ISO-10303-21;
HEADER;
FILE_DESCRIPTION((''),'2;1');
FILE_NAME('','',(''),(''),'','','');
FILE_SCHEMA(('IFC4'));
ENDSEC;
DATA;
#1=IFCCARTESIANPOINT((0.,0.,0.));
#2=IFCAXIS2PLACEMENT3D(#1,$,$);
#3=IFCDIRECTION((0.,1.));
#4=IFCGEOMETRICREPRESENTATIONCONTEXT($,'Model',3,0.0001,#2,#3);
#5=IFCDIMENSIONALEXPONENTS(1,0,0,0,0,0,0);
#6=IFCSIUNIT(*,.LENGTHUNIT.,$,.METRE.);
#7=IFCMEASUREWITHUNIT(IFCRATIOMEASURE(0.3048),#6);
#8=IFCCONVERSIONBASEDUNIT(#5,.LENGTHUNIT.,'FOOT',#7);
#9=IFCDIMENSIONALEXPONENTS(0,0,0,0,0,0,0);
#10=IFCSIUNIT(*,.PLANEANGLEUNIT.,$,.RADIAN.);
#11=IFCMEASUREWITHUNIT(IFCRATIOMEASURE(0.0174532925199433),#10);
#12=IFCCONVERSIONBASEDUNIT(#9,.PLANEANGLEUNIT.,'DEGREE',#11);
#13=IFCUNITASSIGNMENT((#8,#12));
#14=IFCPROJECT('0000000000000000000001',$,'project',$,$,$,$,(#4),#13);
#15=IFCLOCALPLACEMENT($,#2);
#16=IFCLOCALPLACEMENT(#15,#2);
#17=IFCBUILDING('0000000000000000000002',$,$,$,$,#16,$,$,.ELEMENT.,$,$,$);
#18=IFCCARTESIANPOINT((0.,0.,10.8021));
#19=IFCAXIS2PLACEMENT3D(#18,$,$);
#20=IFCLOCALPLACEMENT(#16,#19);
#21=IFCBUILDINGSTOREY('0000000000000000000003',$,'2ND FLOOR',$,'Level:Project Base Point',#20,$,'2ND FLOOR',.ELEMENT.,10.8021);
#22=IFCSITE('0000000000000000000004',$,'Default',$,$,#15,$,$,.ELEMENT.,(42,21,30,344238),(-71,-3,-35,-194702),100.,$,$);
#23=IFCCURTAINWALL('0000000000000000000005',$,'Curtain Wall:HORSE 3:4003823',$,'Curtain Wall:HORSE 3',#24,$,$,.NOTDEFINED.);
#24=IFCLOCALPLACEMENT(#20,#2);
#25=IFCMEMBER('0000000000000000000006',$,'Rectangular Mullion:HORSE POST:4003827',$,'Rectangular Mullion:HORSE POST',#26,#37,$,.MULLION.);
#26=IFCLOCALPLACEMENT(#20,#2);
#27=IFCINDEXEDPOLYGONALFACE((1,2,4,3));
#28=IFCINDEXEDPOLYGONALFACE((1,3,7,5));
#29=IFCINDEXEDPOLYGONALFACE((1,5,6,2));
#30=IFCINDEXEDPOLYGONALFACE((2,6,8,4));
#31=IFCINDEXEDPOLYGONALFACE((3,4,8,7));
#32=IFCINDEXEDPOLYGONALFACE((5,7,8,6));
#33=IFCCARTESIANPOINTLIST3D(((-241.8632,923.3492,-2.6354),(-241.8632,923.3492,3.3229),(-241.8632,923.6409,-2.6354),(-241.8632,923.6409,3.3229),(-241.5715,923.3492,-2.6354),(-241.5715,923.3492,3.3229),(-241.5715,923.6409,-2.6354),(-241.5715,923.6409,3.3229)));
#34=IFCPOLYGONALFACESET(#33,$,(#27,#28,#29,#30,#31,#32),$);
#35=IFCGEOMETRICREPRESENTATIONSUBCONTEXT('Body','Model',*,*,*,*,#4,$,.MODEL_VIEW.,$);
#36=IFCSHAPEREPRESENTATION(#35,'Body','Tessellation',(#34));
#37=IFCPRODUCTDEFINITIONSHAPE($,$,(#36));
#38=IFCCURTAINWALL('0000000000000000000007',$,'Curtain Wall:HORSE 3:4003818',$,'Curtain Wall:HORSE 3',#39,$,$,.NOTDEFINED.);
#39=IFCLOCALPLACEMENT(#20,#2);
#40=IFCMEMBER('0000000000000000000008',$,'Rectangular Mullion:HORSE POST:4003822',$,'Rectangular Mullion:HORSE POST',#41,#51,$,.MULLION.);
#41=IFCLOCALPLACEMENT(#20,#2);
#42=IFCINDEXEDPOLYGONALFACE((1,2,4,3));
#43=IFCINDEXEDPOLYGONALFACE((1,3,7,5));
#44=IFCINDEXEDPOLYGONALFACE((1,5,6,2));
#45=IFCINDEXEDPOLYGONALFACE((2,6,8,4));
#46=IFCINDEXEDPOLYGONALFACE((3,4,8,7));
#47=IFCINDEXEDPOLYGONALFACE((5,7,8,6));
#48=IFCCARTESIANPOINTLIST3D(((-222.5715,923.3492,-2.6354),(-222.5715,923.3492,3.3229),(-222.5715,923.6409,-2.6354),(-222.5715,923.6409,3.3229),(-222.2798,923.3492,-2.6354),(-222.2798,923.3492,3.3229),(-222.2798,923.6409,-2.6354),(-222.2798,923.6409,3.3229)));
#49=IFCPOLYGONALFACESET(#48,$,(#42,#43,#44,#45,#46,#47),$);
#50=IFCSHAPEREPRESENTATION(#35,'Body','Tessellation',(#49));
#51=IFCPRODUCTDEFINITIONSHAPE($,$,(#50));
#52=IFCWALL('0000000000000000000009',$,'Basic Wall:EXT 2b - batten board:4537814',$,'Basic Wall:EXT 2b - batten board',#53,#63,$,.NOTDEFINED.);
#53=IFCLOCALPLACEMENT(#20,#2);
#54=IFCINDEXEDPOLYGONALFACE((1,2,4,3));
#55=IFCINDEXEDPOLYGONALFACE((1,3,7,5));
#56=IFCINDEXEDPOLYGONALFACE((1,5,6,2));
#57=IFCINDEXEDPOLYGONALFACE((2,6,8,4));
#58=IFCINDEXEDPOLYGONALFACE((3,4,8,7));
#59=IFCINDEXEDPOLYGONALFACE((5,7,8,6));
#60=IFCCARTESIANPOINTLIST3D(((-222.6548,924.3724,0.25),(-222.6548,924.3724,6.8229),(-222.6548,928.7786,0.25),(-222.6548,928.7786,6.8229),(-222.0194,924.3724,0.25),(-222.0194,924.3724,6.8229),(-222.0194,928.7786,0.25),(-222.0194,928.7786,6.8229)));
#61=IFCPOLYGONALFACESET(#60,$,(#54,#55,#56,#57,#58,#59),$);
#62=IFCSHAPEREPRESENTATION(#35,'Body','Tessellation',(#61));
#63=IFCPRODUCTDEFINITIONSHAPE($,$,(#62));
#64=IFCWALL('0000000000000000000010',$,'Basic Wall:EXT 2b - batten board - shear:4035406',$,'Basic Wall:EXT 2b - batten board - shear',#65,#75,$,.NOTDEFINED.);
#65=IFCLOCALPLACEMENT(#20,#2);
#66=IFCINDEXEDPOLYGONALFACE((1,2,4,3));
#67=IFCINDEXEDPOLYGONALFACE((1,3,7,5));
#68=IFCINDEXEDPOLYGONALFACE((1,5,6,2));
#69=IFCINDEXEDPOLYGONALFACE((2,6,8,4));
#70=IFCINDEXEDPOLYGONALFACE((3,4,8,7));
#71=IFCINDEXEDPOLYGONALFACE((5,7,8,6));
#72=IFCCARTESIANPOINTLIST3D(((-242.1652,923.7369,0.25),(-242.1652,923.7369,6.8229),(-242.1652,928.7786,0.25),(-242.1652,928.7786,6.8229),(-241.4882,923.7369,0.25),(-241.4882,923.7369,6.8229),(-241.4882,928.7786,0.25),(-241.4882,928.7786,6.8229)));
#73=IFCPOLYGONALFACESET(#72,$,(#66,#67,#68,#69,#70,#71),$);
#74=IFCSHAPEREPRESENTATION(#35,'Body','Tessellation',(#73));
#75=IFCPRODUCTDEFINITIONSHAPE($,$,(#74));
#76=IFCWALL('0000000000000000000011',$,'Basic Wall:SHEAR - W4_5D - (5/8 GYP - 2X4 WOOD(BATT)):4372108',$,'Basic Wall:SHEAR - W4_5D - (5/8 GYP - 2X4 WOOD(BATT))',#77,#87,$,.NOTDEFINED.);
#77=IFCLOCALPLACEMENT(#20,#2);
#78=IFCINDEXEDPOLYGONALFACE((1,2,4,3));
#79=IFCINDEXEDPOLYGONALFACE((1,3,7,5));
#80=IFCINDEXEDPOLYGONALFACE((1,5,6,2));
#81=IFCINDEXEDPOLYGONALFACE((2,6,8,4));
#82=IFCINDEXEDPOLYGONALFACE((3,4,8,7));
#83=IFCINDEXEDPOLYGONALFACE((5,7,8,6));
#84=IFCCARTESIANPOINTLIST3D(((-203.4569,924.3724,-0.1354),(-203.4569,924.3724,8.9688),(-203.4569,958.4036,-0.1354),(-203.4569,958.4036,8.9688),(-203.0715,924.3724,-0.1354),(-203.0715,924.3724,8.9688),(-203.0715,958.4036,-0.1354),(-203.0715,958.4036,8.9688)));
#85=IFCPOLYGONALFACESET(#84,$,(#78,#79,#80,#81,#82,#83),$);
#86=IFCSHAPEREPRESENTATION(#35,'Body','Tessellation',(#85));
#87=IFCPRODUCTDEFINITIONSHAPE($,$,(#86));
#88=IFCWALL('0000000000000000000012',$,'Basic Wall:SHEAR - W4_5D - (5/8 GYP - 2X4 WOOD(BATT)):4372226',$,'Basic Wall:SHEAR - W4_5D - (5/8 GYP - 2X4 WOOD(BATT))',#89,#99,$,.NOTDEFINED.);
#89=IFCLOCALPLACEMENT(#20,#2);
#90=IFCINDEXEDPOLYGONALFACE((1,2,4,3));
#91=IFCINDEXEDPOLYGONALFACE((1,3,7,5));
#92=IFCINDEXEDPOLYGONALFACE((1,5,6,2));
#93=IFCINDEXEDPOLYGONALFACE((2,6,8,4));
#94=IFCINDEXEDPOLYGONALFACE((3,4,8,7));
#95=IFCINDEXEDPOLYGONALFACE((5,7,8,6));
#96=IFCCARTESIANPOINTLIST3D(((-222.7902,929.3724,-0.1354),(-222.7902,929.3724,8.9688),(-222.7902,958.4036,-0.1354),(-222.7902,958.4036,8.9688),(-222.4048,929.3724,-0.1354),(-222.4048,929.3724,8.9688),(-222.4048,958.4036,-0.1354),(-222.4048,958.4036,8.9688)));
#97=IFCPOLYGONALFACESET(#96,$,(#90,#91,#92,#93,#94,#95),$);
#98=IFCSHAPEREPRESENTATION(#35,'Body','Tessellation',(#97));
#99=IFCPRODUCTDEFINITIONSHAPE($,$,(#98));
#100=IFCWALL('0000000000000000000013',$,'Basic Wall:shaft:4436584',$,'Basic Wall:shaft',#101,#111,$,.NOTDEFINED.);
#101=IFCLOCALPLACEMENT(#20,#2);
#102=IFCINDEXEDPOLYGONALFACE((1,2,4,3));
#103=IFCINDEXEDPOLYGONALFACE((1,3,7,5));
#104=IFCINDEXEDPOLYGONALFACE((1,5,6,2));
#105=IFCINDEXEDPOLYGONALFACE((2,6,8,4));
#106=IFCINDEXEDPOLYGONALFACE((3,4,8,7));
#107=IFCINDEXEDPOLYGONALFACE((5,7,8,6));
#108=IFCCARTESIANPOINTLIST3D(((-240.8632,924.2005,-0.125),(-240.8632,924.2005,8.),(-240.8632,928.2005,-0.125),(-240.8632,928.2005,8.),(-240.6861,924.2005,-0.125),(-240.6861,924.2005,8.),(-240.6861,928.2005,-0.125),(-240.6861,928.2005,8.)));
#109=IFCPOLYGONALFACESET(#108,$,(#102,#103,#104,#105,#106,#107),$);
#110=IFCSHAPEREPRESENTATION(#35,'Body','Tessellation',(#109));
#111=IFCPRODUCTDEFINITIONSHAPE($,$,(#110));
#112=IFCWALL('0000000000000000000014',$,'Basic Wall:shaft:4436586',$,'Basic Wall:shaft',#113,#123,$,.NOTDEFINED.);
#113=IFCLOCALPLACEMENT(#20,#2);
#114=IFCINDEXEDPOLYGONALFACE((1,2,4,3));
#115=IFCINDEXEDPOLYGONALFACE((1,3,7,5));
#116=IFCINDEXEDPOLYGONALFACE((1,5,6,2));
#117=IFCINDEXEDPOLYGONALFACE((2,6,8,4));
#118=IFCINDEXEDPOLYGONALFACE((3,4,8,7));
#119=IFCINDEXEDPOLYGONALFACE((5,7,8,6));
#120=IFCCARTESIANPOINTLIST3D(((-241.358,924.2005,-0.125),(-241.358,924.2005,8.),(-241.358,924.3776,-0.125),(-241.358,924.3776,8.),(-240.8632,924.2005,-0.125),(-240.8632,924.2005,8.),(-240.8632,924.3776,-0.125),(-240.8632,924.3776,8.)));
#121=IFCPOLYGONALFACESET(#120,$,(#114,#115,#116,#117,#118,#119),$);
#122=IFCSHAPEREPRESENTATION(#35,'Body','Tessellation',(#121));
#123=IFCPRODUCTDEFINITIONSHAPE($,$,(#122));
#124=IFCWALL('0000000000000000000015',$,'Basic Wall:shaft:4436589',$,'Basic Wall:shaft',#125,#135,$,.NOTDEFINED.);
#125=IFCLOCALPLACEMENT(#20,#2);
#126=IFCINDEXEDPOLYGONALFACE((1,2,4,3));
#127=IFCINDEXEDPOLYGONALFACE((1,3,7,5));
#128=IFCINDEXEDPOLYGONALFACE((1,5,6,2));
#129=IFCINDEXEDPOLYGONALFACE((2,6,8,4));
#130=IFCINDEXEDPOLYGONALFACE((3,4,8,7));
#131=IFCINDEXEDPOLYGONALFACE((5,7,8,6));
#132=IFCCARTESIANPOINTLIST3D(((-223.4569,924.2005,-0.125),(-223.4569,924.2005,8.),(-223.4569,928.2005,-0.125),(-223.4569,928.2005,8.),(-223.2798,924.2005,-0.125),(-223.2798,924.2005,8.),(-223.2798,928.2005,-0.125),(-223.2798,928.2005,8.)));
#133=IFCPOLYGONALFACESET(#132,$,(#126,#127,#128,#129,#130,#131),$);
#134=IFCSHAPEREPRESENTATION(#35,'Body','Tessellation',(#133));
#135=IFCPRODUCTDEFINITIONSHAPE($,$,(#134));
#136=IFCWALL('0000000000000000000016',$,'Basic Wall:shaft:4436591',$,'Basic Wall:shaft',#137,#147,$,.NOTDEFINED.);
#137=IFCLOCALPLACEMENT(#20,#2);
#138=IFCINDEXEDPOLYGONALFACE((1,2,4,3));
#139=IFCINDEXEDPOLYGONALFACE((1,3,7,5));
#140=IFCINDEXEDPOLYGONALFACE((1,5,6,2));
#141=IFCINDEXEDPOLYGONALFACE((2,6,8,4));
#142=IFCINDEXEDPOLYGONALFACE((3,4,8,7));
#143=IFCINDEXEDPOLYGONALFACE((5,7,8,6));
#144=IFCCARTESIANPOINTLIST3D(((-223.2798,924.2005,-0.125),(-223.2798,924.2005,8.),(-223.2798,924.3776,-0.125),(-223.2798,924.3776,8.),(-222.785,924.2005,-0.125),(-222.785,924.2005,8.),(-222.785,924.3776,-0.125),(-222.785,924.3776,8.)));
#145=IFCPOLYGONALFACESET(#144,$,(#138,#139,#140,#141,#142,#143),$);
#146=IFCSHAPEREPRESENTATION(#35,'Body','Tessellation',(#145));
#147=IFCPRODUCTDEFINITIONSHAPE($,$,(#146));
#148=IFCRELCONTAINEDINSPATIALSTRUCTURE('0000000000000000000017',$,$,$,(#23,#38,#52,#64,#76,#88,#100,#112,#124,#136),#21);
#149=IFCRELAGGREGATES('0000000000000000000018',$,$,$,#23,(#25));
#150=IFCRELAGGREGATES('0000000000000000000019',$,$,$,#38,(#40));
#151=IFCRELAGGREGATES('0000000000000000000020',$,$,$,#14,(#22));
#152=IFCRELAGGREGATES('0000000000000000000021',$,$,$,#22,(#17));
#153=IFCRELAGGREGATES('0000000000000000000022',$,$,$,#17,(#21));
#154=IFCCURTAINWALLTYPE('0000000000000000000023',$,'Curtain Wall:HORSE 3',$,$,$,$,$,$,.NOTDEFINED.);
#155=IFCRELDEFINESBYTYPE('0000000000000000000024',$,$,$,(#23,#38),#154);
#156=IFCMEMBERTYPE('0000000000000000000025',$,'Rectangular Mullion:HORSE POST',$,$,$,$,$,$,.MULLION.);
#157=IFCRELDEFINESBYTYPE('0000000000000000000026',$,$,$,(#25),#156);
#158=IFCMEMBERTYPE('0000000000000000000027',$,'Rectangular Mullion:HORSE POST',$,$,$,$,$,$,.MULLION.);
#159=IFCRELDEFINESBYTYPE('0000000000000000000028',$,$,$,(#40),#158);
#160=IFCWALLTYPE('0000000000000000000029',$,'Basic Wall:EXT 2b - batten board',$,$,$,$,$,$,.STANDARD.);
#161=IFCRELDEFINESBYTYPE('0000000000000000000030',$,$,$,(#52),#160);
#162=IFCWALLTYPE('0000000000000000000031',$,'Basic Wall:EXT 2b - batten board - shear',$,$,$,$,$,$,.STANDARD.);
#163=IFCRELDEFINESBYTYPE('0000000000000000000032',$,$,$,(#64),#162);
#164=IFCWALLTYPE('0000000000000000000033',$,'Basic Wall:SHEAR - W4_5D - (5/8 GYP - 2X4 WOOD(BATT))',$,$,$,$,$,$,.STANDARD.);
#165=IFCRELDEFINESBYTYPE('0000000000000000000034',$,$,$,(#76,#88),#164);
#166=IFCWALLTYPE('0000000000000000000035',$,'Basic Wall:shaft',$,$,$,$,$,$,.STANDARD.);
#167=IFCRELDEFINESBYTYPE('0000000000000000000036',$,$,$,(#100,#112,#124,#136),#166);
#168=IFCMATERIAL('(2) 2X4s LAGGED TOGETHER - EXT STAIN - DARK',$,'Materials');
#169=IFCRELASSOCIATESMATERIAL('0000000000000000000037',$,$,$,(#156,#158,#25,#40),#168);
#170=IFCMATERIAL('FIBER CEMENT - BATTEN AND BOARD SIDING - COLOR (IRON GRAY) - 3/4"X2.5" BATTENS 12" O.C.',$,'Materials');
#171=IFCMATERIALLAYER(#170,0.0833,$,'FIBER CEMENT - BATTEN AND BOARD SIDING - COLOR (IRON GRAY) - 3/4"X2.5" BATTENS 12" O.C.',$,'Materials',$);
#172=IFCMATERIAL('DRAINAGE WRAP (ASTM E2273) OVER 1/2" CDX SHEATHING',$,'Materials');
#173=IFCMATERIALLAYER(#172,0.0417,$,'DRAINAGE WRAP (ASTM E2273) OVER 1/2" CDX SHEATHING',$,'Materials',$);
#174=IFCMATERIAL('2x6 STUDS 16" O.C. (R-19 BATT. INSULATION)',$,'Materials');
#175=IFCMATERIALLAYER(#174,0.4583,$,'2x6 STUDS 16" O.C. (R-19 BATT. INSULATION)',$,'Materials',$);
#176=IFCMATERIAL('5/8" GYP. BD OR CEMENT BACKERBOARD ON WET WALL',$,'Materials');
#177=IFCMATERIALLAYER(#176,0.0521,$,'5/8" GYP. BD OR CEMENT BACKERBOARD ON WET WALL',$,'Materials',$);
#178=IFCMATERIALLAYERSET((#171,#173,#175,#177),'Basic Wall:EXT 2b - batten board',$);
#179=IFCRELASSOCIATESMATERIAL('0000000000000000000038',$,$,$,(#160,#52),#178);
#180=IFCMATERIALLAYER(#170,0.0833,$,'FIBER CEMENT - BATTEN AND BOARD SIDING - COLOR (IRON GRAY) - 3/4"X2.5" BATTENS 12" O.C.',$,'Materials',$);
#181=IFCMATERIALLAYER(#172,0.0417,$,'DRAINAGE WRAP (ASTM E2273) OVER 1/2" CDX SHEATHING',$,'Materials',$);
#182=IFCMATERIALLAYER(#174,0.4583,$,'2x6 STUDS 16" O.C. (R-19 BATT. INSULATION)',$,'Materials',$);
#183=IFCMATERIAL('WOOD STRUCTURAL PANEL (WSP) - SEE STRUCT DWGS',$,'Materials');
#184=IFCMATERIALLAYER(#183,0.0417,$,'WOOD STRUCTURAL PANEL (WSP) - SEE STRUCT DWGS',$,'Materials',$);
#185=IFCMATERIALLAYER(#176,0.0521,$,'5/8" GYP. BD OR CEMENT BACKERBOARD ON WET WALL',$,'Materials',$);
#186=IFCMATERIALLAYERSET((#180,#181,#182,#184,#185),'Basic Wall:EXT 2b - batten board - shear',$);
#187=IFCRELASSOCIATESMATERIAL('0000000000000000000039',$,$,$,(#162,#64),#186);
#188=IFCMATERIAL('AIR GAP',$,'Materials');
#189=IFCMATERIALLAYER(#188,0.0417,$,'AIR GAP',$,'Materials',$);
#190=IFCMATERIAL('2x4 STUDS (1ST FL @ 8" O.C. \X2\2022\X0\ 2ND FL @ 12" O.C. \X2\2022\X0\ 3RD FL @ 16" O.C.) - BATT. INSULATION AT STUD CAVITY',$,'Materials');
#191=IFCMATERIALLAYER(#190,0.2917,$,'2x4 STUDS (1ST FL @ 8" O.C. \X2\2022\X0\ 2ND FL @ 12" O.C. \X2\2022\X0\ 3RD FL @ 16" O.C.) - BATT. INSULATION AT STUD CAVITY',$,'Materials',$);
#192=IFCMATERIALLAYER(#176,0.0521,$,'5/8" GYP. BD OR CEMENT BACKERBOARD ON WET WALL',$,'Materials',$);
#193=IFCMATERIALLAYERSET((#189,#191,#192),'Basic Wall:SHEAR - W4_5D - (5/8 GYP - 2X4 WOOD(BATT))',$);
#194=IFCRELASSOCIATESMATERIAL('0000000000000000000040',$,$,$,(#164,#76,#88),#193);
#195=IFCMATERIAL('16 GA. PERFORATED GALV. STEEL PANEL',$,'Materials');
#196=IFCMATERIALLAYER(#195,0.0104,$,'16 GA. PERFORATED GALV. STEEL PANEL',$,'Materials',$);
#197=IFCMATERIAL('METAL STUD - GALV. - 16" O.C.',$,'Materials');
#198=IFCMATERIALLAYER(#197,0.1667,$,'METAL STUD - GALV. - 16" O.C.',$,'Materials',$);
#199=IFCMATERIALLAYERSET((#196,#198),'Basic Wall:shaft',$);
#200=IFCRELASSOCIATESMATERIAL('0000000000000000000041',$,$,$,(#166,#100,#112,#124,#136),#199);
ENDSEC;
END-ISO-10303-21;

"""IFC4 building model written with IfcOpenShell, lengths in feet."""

from ifc_helpers import new_model, entity, si_unit, converted_unit, direction, frame, frame_2d, origin, origin_2d_with_axis, place, context, subcontext, project, spatial, rectangle, extrude, source, transform, mapped, material, layer, layer_set, layer_usage, material_profile, profile_set, profile_usage, type_object, type_shapes, element, aggregate, save


model = new_model("IFC4")

# Units and contexts
model_context = context("Model", 3, precision=0.0001, world=origin(), true_north=direction((0.0, 1.0)))
body_context = subcontext(model_context, "Body", "Model", "MODEL_VIEW")
ifc_project = project(units=[converted_unit("LENGTHUNIT", "FOOT", entity("IfcRatioMeasure", 0.3048), si_unit("LENGTHUNIT", "METRE"), dimensions=[1, 0, 0, 0, 0, 0, 0]), converted_unit("PLANEANGLEUNIT", "DEGREE", entity("IfcRatioMeasure", 0.0174532925199433), si_unit("PLANEANGLEUNIT", "RADIAN"), dimensions=[0, 0, 0, 0, 0, 0, 0])], contexts=[model_context])

# Site, building, storey
site_placement = place(None, origin())
site = spatial("IfcSite", under=ifc_project, at=site_placement, Name="Default", CompositionType="ELEMENT", RefLatitude=(42, 21, 30, 344238), RefLongitude=(-71, -3, -35, -194702), RefElevation=100.0)
building_placement = place(site_placement, origin())
building = spatial("IfcBuilding", under=site, at=building_placement, CompositionType="ELEMENT")
storey_placement = place(building_placement, frame((0.0, 0.0, 10.8021)))
storey = spatial("IfcBuildingStorey", under=building, at=storey_placement, Name="2ND FLOOR", ObjectType="Level:Project Base Point", LongName="2ND FLOOR", CompositionType="ELEMENT", Elevation=10.8021)

# Curtain walls, members
curtain_wall_type = type_object("IfcCurtainWallType", Name="Curtain Wall:HORSE 3", PredefinedType="NOTDEFINED")
curtain_wall_1_placement = place(storey_placement, frame((0.0, 0.0, -10.8021)))
curtain_wall_1 = element("IfcCurtainWall", 1, at=curtain_wall_1_placement, inside=storey, type_object=curtain_wall_type, Name="Curtain Wall:HORSE 3:4003823", ObjectType="Curtain Wall:HORSE 3", PredefinedType="NOTDEFINED")
ifc_material_1 = material(Name="(2) 2X4s LAGGED TOGETHER - EXT STAIN - DARK", Category="Materials")
ifc_material_profile = material_profile(ifc_material_1, rectangle(XDim=0.2917, YDim=0.2917, at=frame_2d((0.0, 0.0), x_axis=(1.0, 0.0))), Name="HORSE POST")
ifc_profile_set = profile_set([ifc_material_profile], Name="HORSE POST")
ifc_profile_usage_1 = profile_usage(ifc_profile_set)
member_type_1 = type_object("IfcMemberType", Name="Rectangular Mullion:HORSE POST", PredefinedType="MULLION", material=ifc_profile_set)
shared_shape_1 = source(origin(), body_context, "Body", "SweptSolid", [
    extrude(rectangle(XDim=0.2917, YDim=0.2917, at=origin_2d_with_axis()), frame((-0.1458, 0.1458, -5.9583), z_axis=(0.0, 0.0, 1.0), x_axis=(0.0, -1.0, 0.0)), (0.0, 0.0, 1.0), 5.9583),
])
type_shapes(member_type_1, [shared_shape_1])
placement = place(building_placement, frame((0.0, 0.0, 21.4688)))
member_1_placement = place(placement, frame((-241.5715, 923.6409, -7.3438), z_axis=(0.0, 0.0, 1.0), x_axis=(0.0, 1.0, 0.0)))
member_1 = element("IfcMember", 2, at=member_1_placement, type_object=member_type_1, material=ifc_profile_usage_1, Name="Rectangular Mullion:HORSE POST:4003827", ObjectType="Rectangular Mullion:HORSE POST", PredefinedType="MULLION", context=body_context, shape_type="MappedRepresentation", body=[
    mapped(shared_shape_1, transform((0.0, 0.0, 0.0), scale=1.0)),
])
aggregate(curtain_wall_1, [member_1])
curtain_wall_2_placement = place(storey_placement, frame((0.0, 0.0, -10.8021)))
curtain_wall_2 = element("IfcCurtainWall", 3, at=curtain_wall_2_placement, inside=storey, type_object=curtain_wall_type, Name="Curtain Wall:HORSE 3:4003818", ObjectType="Curtain Wall:HORSE 3", PredefinedType="NOTDEFINED")
ifc_profile_usage_2 = profile_usage(ifc_profile_set)
member_type_2 = type_object("IfcMemberType", Name="Rectangular Mullion:HORSE POST", PredefinedType="MULLION", material=ifc_profile_set)
shared_shape_2 = source(origin(), body_context, "Body", "SweptSolid", [
    extrude(rectangle(XDim=0.2917, YDim=0.2917, at=frame_2d((0.0, 0.0), x_axis=(1.0, 0.0))), frame((-0.1458, -0.1458, -5.9583), z_axis=(0.0, 0.0, 1.0), x_axis=(0.0, -1.0, 0.0)), (0.0, 0.0, 1.0), 5.9583),
])
type_shapes(member_type_2, [shared_shape_2])
member_2_placement = place(placement, frame((-222.5715, 923.6409, -7.3437), z_axis=(0.0, 0.0, 1.0), x_axis=(0.0, 1.0, 0.0)))
member_2 = element("IfcMember", 4, at=member_2_placement, type_object=member_type_2, material=ifc_profile_usage_2, Name="Rectangular Mullion:HORSE POST:4003822", ObjectType="Rectangular Mullion:HORSE POST", PredefinedType="MULLION", context=body_context, shape_type="MappedRepresentation", body=[
    mapped(shared_shape_2, transform((0.0, 0.0, 0.0), scale=1.0)),
])
aggregate(curtain_wall_2, [member_2])

# Walls
ifc_material_2 = material(Name="FIBER CEMENT - BATTEN AND BOARD SIDING - COLOR (IRON GRAY) - 3/4\"X2.5\" BATTENS 12\" O.C.", Category="Materials")
ifc_layer_1 = layer(ifc_material_2, 0.0833, Name="FIBER CEMENT - BATTEN AND BOARD SIDING - COLOR (IRON GRAY) - 3/4\"X2.5\" BATTENS 12\" O.C.", Category="Materials")
ifc_material_3 = material(Name="DRAINAGE WRAP (ASTM E2273) OVER 1/2\" CDX SHEATHING", Category="Materials")
ifc_layer_2 = layer(ifc_material_3, 0.0417, Name="DRAINAGE WRAP (ASTM E2273) OVER 1/2\" CDX SHEATHING", Category="Materials")
ifc_material_4 = material(Name="2x6 STUDS 16\" O.C. (R-19 BATT. INSULATION)", Category="Materials")
ifc_layer_3 = layer(ifc_material_4, 0.4583, Name="2x6 STUDS 16\" O.C. (R-19 BATT. INSULATION)", Category="Materials")
ifc_material_5 = material(Name="5/8\" GYP. BD OR CEMENT BACKERBOARD ON WET WALL", Category="Materials")
ifc_layer_4 = layer(ifc_material_5, 0.0521, Name="5/8\" GYP. BD OR CEMENT BACKERBOARD ON WET WALL", Category="Materials")
ifc_layer_set_1 = layer_set([ifc_layer_1, ifc_layer_2, ifc_layer_3, ifc_layer_4], Name="Basic Wall:EXT 2b - batten board")
ifc_layer_usage_1 = layer_usage(ifc_layer_set_1, "AXIS2", "POSITIVE", -0.3177)
wall_type_1 = type_object("IfcWallType", Name="Basic Wall:EXT 2b - batten board", PredefinedType="STANDARD", material=ifc_layer_set_1)
wall_1_placement = place(storey_placement, frame((-222.3371, 928.7786, 0.25), z_axis=(0.0, 0.0, 1.0), x_axis=(0.0, -1.0, 0.0)))
element("IfcWall", 5, at=wall_1_placement, inside=storey, type_object=wall_type_1, material=ifc_layer_usage_1, Name="Basic Wall:EXT 2b - batten board:4537814", ObjectType="Basic Wall:EXT 2b - batten board", PredefinedType="NOTDEFINED", context=body_context, shape_type="SweptSolid", body=[
    extrude(rectangle(XDim=4.4063, YDim=0.6354, at=frame_2d((2.2031, 0.0), x_axis=(-1.0, 0.0))), origin(), (0.0, 0.0, 1.0), 6.5729),
])
ifc_layer_5 = layer(ifc_material_2, 0.0833, Name="FIBER CEMENT - BATTEN AND BOARD SIDING - COLOR (IRON GRAY) - 3/4\"X2.5\" BATTENS 12\" O.C.", Category="Materials")
ifc_layer_6 = layer(ifc_material_3, 0.0417, Name="DRAINAGE WRAP (ASTM E2273) OVER 1/2\" CDX SHEATHING", Category="Materials")
ifc_layer_7 = layer(ifc_material_4, 0.4583, Name="2x6 STUDS 16\" O.C. (R-19 BATT. INSULATION)", Category="Materials")
ifc_material_6 = material(Name="WOOD STRUCTURAL PANEL (WSP) - SEE STRUCT DWGS", Category="Materials")
ifc_layer_8 = layer(ifc_material_6, 0.0417, Name="WOOD STRUCTURAL PANEL (WSP) - SEE STRUCT DWGS", Category="Materials")
ifc_layer_9 = layer(ifc_material_5, 0.0521, Name="5/8\" GYP. BD OR CEMENT BACKERBOARD ON WET WALL", Category="Materials")
ifc_layer_set_2 = layer_set([ifc_layer_5, ifc_layer_6, ifc_layer_7, ifc_layer_8, ifc_layer_9], Name="Basic Wall:EXT 2b - batten board - shear")
ifc_layer_usage_2 = layer_usage(ifc_layer_set_2, "AXIS2", "NEGATIVE", 0.3385)
wall_type_2 = type_object("IfcWallType", Name="Basic Wall:EXT 2b - batten board - shear", PredefinedType="STANDARD", material=ifc_layer_set_2)
wall_2_placement = place(storey_placement, frame((-241.8267, 928.7786, 0.25), z_axis=(0.0, 0.0, 1.0), x_axis=(0.0, -1.0, 0.0)))
element("IfcWall", 6, at=wall_2_placement, inside=storey, type_object=wall_type_2, material=ifc_layer_usage_2, Name="Basic Wall:EXT 2b - batten board - shear:4035406", ObjectType="Basic Wall:EXT 2b - batten board - shear", PredefinedType="NOTDEFINED", context=body_context, shape_type="SweptSolid", body=[
    extrude(rectangle(XDim=5.0417, YDim=0.6771, at=frame_2d((2.5208, 0.0), x_axis=(-1.0, 0.0))), origin(), (0.0, 0.0, 1.0), 6.5729),
])
ifc_material_7 = material(Name="AIR GAP", Category="Materials")
ifc_layer_10 = layer(ifc_material_7, 0.0417, Name="AIR GAP", Category="Materials")
ifc_material_8 = material(Name="2x4 STUDS (1ST FL @ 8\" O.C. • 2ND FL @ 12\" O.C. • 3RD FL @ 16\" O.C.) - BATT. INSULATION AT STUD CAVITY", Category="Materials")
ifc_layer_11 = layer(ifc_material_8, 0.2917, Name="2x4 STUDS (1ST FL @ 8\" O.C. • 2ND FL @ 12\" O.C. • 3RD FL @ 16\" O.C.) - BATT. INSULATION AT STUD CAVITY", Category="Materials")
ifc_layer_12 = layer(ifc_material_5, 0.0521, Name="5/8\" GYP. BD OR CEMENT BACKERBOARD ON WET WALL", Category="Materials")
ifc_layer_set_3 = layer_set([ifc_layer_10, ifc_layer_11, ifc_layer_12], Name="Basic Wall:SHEAR - W4_5D - (5/8 GYP - 2X4 WOOD(BATT))")
ifc_layer_usage_3 = layer_usage(ifc_layer_set_3, "AXIS2", "POSITIVE", -0.1927)
wall_type_3 = type_object("IfcWallType", Name="Basic Wall:SHEAR - W4_5D - (5/8 GYP - 2X4 WOOD(BATT))", PredefinedType="STANDARD", material=ifc_layer_set_3)
wall_3_placement = place(storey_placement, frame((-203.2642, 924.3724, -0.1354), z_axis=(0.0, 0.0, 1.0), x_axis=(0.0, 1.0, 0.0)))
element("IfcWall", 7, at=wall_3_placement, inside=storey, type_object=wall_type_3, material=ifc_layer_usage_3, Name="Basic Wall:SHEAR - W4_5D - (5/8 GYP - 2X4 WOOD(BATT)):4372108", ObjectType="Basic Wall:SHEAR - W4_5D - (5/8 GYP - 2X4 WOOD(BATT))", PredefinedType="NOTDEFINED", context=body_context, shape_type="SweptSolid", body=[
    extrude(rectangle(XDim=34.0313, YDim=0.3854, at=frame_2d((17.0156, 0.0), x_axis=(-1.0, 0.0))), origin(), (0.0, 0.0, 1.0), 9.1042),
])
ifc_layer_usage_4 = layer_usage(ifc_layer_set_3, "AXIS2", "POSITIVE", -0.1927)
wall_4_placement = place(storey_placement, frame((-222.5975, 929.3724, -0.1354), z_axis=(0.0, 0.0, 1.0), x_axis=(0.0, 1.0, 0.0)))
element("IfcWall", 8, at=wall_4_placement, inside=storey, type_object=wall_type_3, material=ifc_layer_usage_4, Name="Basic Wall:SHEAR - W4_5D - (5/8 GYP - 2X4 WOOD(BATT)):4372226", ObjectType="Basic Wall:SHEAR - W4_5D - (5/8 GYP - 2X4 WOOD(BATT))", PredefinedType="NOTDEFINED", context=body_context, shape_type="SweptSolid", body=[
    extrude(rectangle(XDim=29.0313, YDim=0.3854, at=frame_2d((14.5156, 0.0), x_axis=(-1.0, 0.0))), origin(), (0.0, 0.0, 1.0), 9.1042),
])
ifc_material_9 = material(Name="16 GA. PERFORATED GALV. STEEL PANEL", Category="Materials")
ifc_layer_13 = layer(ifc_material_9, 0.0104, Name="16 GA. PERFORATED GALV. STEEL PANEL", Category="Materials")
ifc_material_10 = material(Name="METAL STUD - GALV. - 16\" O.C.", Category="Materials")
ifc_layer_14 = layer(ifc_material_10, 0.1667, Name="METAL STUD - GALV. - 16\" O.C.", Category="Materials")
ifc_layer_set_4 = layer_set([ifc_layer_13, ifc_layer_14], Name="Basic Wall:shaft")
ifc_layer_usage_5 = layer_usage(ifc_layer_set_4, "AXIS2", "NEGATIVE", 0.0885)
wall_type_4 = type_object("IfcWallType", Name="Basic Wall:shaft", PredefinedType="STANDARD", material=ifc_layer_set_4)
wall_5_placement = place(storey_placement, frame((-240.7746, 928.2005, -0.125), z_axis=(0.0, 0.0, 1.0), x_axis=(0.0, -1.0, 0.0)))
element("IfcWall", 9, at=wall_5_placement, inside=storey, type_object=wall_type_4, material=ifc_layer_usage_5, Name="Basic Wall:shaft:4436584", ObjectType="Basic Wall:shaft", PredefinedType="NOTDEFINED", context=body_context, shape_type="SweptSolid", body=[
    extrude(rectangle(XDim=4.0, YDim=0.1771, at=frame_2d((2.0, 0.0), x_axis=(-1.0, 0.0))), origin(), (0.0, 0.0, 1.0), 8.125),
])
ifc_layer_usage_6 = layer_usage(ifc_layer_set_4, "AXIS2", "POSITIVE", -0.0885)
wall_6_placement = place(storey_placement, frame((-241.358, 924.289, -0.125)))
element("IfcWall", 10, at=wall_6_placement, inside=storey, type_object=wall_type_4, material=ifc_layer_usage_6, Name="Basic Wall:shaft:4436586", ObjectType="Basic Wall:shaft", PredefinedType="NOTDEFINED", context=body_context, shape_type="SweptSolid", body=[
    extrude(rectangle(XDim=0.4948, YDim=0.1771, at=frame_2d((0.2474, 0.0), x_axis=(-1.0, 0.0))), origin(), (0.0, 0.0, 1.0), 8.125),
])
ifc_layer_usage_7 = layer_usage(ifc_layer_set_4, "AXIS2", "POSITIVE", -0.0885)
wall_7_placement = place(storey_placement, frame((-223.3684, 928.2005, -0.125), z_axis=(0.0, 0.0, 1.0), x_axis=(0.0, -1.0, 0.0)))
element("IfcWall", 11, at=wall_7_placement, inside=storey, type_object=wall_type_4, material=ifc_layer_usage_7, Name="Basic Wall:shaft:4436589", ObjectType="Basic Wall:shaft", PredefinedType="NOTDEFINED", context=body_context, shape_type="SweptSolid", body=[
    extrude(rectangle(XDim=4.0, YDim=0.1771, at=frame_2d((2.0, 0.0), x_axis=(-1.0, 0.0))), origin(), (0.0, 0.0, 1.0), 8.125),
])
ifc_layer_usage_8 = layer_usage(ifc_layer_set_4, "AXIS2", "NEGATIVE", 0.0885)
wall_8_placement = place(storey_placement, frame((-222.785, 924.289, -0.125), z_axis=(0.0, 0.0, 1.0), x_axis=(-1.0, 0.0, 0.0)))
element("IfcWall", 12, at=wall_8_placement, inside=storey, type_object=wall_type_4, material=ifc_layer_usage_8, Name="Basic Wall:shaft:4436591", ObjectType="Basic Wall:shaft", PredefinedType="NOTDEFINED", context=body_context, shape_type="SweptSolid", body=[
    extrude(rectangle(XDim=0.4948, YDim=0.1771, at=frame_2d((0.2474, 0.0), x_axis=(-1.0, 0.0))), origin(), (0.0, 0.0, 1.0), 8.125),
])

save(model, "model.ifc")
